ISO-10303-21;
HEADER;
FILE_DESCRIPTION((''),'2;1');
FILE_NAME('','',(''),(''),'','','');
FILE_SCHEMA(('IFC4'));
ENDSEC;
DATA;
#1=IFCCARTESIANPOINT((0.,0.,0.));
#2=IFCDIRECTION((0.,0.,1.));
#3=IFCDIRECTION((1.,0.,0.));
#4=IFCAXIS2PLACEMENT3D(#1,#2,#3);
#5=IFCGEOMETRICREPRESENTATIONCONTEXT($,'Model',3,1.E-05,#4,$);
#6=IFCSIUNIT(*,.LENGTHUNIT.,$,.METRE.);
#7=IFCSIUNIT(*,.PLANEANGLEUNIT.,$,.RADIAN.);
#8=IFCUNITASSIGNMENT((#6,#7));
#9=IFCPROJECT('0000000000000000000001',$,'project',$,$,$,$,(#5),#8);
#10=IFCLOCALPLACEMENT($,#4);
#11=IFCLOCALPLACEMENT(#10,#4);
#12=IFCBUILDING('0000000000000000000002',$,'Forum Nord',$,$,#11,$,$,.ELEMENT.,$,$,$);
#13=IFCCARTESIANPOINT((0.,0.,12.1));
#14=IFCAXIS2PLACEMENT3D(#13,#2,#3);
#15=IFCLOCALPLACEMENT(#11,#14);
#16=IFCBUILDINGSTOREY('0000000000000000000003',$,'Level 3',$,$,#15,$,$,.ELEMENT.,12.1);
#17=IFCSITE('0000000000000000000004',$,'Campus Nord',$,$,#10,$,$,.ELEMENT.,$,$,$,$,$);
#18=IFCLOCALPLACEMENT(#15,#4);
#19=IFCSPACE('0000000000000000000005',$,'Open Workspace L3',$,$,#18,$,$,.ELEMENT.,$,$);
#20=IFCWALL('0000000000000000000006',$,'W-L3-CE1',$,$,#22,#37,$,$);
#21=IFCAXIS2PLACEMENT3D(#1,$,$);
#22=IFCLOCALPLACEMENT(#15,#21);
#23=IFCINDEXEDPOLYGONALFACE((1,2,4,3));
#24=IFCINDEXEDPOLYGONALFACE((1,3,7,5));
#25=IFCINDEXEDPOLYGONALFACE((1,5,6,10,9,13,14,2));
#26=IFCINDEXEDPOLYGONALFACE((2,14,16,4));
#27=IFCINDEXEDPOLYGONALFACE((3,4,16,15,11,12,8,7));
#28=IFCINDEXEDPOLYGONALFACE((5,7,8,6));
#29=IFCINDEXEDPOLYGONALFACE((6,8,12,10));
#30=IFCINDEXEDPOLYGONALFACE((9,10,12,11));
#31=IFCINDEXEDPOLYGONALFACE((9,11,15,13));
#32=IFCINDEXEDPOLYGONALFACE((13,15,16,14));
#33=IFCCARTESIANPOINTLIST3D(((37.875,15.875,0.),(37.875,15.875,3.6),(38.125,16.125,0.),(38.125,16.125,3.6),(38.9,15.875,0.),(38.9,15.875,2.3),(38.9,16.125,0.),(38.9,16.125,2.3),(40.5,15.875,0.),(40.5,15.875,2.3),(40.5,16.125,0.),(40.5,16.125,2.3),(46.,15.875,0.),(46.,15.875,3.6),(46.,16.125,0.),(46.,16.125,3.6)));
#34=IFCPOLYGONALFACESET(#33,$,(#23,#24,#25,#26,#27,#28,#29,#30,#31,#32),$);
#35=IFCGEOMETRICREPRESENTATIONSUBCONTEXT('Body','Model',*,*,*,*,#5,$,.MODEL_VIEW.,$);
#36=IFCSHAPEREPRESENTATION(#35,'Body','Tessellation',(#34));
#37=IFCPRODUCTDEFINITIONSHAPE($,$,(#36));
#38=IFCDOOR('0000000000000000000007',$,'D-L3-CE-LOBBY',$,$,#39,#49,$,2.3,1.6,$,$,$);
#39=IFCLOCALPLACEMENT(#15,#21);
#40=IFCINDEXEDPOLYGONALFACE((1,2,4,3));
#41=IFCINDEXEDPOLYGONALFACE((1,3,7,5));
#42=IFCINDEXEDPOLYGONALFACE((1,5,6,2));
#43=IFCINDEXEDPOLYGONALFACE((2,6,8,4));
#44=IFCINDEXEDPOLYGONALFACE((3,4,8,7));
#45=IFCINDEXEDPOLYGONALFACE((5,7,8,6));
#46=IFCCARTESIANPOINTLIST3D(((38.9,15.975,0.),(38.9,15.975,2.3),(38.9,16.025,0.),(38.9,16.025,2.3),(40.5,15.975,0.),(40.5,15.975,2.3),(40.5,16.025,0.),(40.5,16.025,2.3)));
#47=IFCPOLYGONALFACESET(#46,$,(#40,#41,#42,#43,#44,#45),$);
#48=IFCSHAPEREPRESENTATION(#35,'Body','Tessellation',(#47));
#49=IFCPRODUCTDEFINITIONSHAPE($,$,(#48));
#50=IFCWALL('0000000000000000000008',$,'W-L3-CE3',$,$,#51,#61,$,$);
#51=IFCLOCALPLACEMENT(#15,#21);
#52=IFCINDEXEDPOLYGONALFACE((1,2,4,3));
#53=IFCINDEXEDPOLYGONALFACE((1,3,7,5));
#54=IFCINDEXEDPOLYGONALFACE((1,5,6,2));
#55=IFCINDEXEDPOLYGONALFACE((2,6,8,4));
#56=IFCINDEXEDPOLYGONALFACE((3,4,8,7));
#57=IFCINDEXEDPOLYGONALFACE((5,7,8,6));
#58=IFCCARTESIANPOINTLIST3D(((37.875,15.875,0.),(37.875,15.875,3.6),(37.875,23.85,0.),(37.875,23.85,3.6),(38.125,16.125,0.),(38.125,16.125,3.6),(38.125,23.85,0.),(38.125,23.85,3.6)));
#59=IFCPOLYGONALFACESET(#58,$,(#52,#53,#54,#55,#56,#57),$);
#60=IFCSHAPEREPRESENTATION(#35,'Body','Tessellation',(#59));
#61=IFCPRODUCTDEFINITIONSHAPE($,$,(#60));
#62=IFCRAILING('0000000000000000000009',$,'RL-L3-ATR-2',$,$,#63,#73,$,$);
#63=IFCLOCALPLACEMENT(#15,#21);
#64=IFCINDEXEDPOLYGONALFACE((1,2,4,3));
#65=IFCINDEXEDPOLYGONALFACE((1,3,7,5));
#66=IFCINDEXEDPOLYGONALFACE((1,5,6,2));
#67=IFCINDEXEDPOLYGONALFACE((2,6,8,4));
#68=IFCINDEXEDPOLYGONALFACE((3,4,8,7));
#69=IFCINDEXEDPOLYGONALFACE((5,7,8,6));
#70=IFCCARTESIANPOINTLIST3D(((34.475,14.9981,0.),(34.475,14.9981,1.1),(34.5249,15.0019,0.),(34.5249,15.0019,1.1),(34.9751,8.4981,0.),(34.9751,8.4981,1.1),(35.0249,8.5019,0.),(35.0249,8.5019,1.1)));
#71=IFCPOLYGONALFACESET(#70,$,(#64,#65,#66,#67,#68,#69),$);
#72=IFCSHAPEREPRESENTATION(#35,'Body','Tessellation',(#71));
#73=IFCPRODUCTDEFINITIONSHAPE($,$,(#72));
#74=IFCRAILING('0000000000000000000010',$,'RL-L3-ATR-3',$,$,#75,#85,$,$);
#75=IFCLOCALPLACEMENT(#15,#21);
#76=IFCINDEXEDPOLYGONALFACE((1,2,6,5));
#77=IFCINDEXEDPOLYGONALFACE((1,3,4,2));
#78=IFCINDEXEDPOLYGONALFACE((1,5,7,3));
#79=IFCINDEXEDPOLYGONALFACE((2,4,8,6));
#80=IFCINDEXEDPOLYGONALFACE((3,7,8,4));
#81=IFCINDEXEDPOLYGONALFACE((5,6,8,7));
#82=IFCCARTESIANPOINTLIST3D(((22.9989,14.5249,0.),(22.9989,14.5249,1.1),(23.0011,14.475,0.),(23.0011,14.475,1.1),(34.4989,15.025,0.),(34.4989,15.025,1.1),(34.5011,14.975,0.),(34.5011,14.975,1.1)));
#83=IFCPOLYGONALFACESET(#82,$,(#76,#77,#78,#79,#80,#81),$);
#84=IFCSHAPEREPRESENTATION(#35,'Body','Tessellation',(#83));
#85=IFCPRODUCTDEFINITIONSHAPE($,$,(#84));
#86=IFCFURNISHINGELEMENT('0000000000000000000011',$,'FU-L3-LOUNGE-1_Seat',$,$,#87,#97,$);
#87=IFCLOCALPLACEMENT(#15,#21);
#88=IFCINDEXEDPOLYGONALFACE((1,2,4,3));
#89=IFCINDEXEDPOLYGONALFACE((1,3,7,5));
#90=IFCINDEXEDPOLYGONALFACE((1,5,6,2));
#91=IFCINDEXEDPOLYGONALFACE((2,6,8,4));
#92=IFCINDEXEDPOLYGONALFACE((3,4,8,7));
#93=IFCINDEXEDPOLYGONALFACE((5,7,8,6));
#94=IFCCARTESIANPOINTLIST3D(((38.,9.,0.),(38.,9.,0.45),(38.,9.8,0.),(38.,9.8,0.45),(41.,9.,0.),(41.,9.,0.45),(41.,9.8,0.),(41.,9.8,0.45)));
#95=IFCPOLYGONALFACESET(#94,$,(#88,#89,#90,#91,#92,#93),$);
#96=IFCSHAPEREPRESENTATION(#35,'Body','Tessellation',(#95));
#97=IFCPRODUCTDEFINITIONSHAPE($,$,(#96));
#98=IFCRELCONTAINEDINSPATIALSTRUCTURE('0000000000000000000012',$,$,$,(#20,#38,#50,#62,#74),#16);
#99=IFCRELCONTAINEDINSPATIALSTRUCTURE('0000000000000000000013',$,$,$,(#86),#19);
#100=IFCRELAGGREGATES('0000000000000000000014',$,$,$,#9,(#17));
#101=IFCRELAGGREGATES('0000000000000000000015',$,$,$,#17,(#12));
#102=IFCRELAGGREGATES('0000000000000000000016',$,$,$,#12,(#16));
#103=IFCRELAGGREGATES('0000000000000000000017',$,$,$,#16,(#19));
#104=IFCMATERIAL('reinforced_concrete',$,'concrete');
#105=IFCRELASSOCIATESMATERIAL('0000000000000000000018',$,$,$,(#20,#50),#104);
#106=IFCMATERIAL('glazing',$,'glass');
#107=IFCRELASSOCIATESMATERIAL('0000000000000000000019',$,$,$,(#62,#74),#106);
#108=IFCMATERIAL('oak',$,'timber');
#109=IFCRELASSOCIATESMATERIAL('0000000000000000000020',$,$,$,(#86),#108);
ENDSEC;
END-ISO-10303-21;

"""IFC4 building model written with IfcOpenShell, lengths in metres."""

from ifc_helpers import new_model, si_unit, frame, frame_2d, origin_with_axes, place, context, subcontext, project, spatial, polyline, rectangle, outline, extrude, material, element, fill, save


model = new_model("IFC4")

# Units and contexts
model_context = context("Model", 3, precision=1e-05, world=origin_with_axes())
body_context = subcontext(model_context, "Body", "Model", "MODEL_VIEW")
ifc_project = project(units=[si_unit("LENGTHUNIT", "METRE"), si_unit("PLANEANGLEUNIT", "RADIAN")], contexts=[model_context])

# Site, building, storey
site_placement = place(None, origin_with_axes())
site = spatial("IfcSite", under=ifc_project, at=site_placement, Name="Campus Nord", CompositionType="ELEMENT")
building_placement = place(site_placement, origin_with_axes())
building = spatial("IfcBuilding", under=site, at=building_placement, Name="Forum Nord", CompositionType="ELEMENT")
storey_placement = place(building_placement, frame((0.0, 0.0, 12.1), z_axis=(0.0, 0.0, 1.0), x_axis=(1.0, 0.0, 0.0)))
storey = spatial("IfcBuildingStorey", under=building, at=storey_placement, Name="Level 3", CompositionType="ELEMENT", Elevation=12.1)

# Wall, opening, door
ifc_material_1 = material(Name="reinforced_concrete", Category="concrete")
wall_1_placement = place(storey_placement, frame((38.0, 16.0, 0.0), z_axis=(0.0, 0.0, 1.0), x_axis=(1.0, 0.0, 0.0)))
wall_1 = element("IfcWall", 1, at=wall_1_placement, inside=storey, material=ifc_material_1, Name="W-L3-CE1", context=body_context, shape_type="SweptSolid", body=[
    extrude(outline(polyline([(-0.125, -0.125), (8.0, -0.125), (8.0, 0.125), (0.125, 0.125), (-0.125, -0.125)])), origin_with_axes(), (0.0, 0.0, 1.0), 3.6),
])
opening_placement = place(storey_placement, frame((38.0, 16.0, 0.0), z_axis=(0.0, 0.0, 1.0), x_axis=(1.0, 0.0, 0.0)))
opening = element("IfcOpeningElement", 2, at=opening_placement, cuts=wall_1, context=body_context, shape_type="SweptSolid", body=[
    extrude(rectangle(XDim=1.6, YDim=0.25, at=frame_2d((1.7, 0.0), x_axis=(1.0, 0.0))), origin_with_axes(), (0.0, 0.0, 1.0), 2.3),
])
door_placement = place(storey_placement, frame((38.0, 16.0, 0.0), z_axis=(0.0, 0.0, 1.0), x_axis=(1.0, 0.0, 0.0)))
door = element("IfcDoor", 3, at=door_placement, inside=storey, Name="D-L3-CE-LOBBY", OverallHeight=2.3, OverallWidth=1.6, context=body_context, shape_type="SweptSolid", body=[
    extrude(rectangle(XDim=1.6, YDim=0.05, at=frame_2d((1.7, 0.0), x_axis=(1.0, 0.0))), origin_with_axes(), (0.0, 0.0, 1.0), 2.3),
])
fill(opening, door)

# Wall
wall_2_placement = place(storey_placement, frame((38.0, 16.0, 0.0), z_axis=(0.0, 0.0, 1.0), x_axis=(0.0, 1.0, 0.0)))
element("IfcWall", 4, at=wall_2_placement, inside=storey, material=ifc_material_1, Name="W-L3-CE3", context=body_context, shape_type="SweptSolid", body=[
    extrude(outline(polyline([(0.125, -0.125), (7.85, -0.125), (7.85, 0.125), (-0.125, 0.125), (0.125, -0.125)])), origin_with_axes(), (0.0, 0.0, 1.0), 3.6),
])

# Railings
ifc_material_2 = material(Name="glazing", Category="glass")
railing_1_placement = place(storey_placement, frame((35.0, 8.5, 0.0), z_axis=(0.0, 0.0, 1.0), x_axis=(-0.0767, 0.99705, 0.0)))
element("IfcRailing", 5, at=railing_1_placement, inside=storey, material=ifc_material_2, Name="RL-L3-ATR-2", context=body_context, shape_type="SweptSolid", body=[
    extrude(rectangle(XDim=6.5192, YDim=0.05, at=frame_2d((3.2596, 0.0), x_axis=(1.0, 0.0))), origin_with_axes(), (0.0, 0.0, 1.0), 1.1),
])
railing_2_placement = place(storey_placement, frame((34.5, 15.0, 0.0), z_axis=(0.0, 0.0, 1.0), x_axis=(-0.99906, -0.04344, 0.0)))
element("IfcRailing", 6, at=railing_2_placement, inside=storey, material=ifc_material_2, Name="RL-L3-ATR-3", context=body_context, shape_type="SweptSolid", body=[
    extrude(rectangle(XDim=11.5109, YDim=0.05, at=frame_2d((5.7554, 0.0), x_axis=(1.0, 0.0))), origin_with_axes(), (0.0, 0.0, 1.0), 1.1),
])

# Shared definitions
space_1_placement = place(storey_placement, origin_with_axes())
space_1 = spatial("IfcSpace", under=storey, at=space_1_placement, Name="Open Workspace L3", CompositionType="ELEMENT")

# Furnishing element
ifc_material_3 = material(Name="oak", Category="timber")
furnishing_1_placement = place(storey_placement, frame((38.0, 9.0, 0.0), z_axis=(0.0, 0.0, 1.0), x_axis=(1.0, 0.0, 0.0)))
element("IfcFurnishingElement", 7, at=furnishing_1_placement, inside=space_1, material=ifc_material_3, Name="FU-L3-LOUNGE-1_Seat", context=body_context, shape_type="SweptSolid", body=[
    extrude(rectangle(XDim=3.0, YDim=0.8, at=frame_2d((1.5, 0.4), x_axis=(1.0, 0.0))), origin_with_axes(), (0.0, 0.0, 1.0), 0.45),
])

save(model, "model.ifc")
